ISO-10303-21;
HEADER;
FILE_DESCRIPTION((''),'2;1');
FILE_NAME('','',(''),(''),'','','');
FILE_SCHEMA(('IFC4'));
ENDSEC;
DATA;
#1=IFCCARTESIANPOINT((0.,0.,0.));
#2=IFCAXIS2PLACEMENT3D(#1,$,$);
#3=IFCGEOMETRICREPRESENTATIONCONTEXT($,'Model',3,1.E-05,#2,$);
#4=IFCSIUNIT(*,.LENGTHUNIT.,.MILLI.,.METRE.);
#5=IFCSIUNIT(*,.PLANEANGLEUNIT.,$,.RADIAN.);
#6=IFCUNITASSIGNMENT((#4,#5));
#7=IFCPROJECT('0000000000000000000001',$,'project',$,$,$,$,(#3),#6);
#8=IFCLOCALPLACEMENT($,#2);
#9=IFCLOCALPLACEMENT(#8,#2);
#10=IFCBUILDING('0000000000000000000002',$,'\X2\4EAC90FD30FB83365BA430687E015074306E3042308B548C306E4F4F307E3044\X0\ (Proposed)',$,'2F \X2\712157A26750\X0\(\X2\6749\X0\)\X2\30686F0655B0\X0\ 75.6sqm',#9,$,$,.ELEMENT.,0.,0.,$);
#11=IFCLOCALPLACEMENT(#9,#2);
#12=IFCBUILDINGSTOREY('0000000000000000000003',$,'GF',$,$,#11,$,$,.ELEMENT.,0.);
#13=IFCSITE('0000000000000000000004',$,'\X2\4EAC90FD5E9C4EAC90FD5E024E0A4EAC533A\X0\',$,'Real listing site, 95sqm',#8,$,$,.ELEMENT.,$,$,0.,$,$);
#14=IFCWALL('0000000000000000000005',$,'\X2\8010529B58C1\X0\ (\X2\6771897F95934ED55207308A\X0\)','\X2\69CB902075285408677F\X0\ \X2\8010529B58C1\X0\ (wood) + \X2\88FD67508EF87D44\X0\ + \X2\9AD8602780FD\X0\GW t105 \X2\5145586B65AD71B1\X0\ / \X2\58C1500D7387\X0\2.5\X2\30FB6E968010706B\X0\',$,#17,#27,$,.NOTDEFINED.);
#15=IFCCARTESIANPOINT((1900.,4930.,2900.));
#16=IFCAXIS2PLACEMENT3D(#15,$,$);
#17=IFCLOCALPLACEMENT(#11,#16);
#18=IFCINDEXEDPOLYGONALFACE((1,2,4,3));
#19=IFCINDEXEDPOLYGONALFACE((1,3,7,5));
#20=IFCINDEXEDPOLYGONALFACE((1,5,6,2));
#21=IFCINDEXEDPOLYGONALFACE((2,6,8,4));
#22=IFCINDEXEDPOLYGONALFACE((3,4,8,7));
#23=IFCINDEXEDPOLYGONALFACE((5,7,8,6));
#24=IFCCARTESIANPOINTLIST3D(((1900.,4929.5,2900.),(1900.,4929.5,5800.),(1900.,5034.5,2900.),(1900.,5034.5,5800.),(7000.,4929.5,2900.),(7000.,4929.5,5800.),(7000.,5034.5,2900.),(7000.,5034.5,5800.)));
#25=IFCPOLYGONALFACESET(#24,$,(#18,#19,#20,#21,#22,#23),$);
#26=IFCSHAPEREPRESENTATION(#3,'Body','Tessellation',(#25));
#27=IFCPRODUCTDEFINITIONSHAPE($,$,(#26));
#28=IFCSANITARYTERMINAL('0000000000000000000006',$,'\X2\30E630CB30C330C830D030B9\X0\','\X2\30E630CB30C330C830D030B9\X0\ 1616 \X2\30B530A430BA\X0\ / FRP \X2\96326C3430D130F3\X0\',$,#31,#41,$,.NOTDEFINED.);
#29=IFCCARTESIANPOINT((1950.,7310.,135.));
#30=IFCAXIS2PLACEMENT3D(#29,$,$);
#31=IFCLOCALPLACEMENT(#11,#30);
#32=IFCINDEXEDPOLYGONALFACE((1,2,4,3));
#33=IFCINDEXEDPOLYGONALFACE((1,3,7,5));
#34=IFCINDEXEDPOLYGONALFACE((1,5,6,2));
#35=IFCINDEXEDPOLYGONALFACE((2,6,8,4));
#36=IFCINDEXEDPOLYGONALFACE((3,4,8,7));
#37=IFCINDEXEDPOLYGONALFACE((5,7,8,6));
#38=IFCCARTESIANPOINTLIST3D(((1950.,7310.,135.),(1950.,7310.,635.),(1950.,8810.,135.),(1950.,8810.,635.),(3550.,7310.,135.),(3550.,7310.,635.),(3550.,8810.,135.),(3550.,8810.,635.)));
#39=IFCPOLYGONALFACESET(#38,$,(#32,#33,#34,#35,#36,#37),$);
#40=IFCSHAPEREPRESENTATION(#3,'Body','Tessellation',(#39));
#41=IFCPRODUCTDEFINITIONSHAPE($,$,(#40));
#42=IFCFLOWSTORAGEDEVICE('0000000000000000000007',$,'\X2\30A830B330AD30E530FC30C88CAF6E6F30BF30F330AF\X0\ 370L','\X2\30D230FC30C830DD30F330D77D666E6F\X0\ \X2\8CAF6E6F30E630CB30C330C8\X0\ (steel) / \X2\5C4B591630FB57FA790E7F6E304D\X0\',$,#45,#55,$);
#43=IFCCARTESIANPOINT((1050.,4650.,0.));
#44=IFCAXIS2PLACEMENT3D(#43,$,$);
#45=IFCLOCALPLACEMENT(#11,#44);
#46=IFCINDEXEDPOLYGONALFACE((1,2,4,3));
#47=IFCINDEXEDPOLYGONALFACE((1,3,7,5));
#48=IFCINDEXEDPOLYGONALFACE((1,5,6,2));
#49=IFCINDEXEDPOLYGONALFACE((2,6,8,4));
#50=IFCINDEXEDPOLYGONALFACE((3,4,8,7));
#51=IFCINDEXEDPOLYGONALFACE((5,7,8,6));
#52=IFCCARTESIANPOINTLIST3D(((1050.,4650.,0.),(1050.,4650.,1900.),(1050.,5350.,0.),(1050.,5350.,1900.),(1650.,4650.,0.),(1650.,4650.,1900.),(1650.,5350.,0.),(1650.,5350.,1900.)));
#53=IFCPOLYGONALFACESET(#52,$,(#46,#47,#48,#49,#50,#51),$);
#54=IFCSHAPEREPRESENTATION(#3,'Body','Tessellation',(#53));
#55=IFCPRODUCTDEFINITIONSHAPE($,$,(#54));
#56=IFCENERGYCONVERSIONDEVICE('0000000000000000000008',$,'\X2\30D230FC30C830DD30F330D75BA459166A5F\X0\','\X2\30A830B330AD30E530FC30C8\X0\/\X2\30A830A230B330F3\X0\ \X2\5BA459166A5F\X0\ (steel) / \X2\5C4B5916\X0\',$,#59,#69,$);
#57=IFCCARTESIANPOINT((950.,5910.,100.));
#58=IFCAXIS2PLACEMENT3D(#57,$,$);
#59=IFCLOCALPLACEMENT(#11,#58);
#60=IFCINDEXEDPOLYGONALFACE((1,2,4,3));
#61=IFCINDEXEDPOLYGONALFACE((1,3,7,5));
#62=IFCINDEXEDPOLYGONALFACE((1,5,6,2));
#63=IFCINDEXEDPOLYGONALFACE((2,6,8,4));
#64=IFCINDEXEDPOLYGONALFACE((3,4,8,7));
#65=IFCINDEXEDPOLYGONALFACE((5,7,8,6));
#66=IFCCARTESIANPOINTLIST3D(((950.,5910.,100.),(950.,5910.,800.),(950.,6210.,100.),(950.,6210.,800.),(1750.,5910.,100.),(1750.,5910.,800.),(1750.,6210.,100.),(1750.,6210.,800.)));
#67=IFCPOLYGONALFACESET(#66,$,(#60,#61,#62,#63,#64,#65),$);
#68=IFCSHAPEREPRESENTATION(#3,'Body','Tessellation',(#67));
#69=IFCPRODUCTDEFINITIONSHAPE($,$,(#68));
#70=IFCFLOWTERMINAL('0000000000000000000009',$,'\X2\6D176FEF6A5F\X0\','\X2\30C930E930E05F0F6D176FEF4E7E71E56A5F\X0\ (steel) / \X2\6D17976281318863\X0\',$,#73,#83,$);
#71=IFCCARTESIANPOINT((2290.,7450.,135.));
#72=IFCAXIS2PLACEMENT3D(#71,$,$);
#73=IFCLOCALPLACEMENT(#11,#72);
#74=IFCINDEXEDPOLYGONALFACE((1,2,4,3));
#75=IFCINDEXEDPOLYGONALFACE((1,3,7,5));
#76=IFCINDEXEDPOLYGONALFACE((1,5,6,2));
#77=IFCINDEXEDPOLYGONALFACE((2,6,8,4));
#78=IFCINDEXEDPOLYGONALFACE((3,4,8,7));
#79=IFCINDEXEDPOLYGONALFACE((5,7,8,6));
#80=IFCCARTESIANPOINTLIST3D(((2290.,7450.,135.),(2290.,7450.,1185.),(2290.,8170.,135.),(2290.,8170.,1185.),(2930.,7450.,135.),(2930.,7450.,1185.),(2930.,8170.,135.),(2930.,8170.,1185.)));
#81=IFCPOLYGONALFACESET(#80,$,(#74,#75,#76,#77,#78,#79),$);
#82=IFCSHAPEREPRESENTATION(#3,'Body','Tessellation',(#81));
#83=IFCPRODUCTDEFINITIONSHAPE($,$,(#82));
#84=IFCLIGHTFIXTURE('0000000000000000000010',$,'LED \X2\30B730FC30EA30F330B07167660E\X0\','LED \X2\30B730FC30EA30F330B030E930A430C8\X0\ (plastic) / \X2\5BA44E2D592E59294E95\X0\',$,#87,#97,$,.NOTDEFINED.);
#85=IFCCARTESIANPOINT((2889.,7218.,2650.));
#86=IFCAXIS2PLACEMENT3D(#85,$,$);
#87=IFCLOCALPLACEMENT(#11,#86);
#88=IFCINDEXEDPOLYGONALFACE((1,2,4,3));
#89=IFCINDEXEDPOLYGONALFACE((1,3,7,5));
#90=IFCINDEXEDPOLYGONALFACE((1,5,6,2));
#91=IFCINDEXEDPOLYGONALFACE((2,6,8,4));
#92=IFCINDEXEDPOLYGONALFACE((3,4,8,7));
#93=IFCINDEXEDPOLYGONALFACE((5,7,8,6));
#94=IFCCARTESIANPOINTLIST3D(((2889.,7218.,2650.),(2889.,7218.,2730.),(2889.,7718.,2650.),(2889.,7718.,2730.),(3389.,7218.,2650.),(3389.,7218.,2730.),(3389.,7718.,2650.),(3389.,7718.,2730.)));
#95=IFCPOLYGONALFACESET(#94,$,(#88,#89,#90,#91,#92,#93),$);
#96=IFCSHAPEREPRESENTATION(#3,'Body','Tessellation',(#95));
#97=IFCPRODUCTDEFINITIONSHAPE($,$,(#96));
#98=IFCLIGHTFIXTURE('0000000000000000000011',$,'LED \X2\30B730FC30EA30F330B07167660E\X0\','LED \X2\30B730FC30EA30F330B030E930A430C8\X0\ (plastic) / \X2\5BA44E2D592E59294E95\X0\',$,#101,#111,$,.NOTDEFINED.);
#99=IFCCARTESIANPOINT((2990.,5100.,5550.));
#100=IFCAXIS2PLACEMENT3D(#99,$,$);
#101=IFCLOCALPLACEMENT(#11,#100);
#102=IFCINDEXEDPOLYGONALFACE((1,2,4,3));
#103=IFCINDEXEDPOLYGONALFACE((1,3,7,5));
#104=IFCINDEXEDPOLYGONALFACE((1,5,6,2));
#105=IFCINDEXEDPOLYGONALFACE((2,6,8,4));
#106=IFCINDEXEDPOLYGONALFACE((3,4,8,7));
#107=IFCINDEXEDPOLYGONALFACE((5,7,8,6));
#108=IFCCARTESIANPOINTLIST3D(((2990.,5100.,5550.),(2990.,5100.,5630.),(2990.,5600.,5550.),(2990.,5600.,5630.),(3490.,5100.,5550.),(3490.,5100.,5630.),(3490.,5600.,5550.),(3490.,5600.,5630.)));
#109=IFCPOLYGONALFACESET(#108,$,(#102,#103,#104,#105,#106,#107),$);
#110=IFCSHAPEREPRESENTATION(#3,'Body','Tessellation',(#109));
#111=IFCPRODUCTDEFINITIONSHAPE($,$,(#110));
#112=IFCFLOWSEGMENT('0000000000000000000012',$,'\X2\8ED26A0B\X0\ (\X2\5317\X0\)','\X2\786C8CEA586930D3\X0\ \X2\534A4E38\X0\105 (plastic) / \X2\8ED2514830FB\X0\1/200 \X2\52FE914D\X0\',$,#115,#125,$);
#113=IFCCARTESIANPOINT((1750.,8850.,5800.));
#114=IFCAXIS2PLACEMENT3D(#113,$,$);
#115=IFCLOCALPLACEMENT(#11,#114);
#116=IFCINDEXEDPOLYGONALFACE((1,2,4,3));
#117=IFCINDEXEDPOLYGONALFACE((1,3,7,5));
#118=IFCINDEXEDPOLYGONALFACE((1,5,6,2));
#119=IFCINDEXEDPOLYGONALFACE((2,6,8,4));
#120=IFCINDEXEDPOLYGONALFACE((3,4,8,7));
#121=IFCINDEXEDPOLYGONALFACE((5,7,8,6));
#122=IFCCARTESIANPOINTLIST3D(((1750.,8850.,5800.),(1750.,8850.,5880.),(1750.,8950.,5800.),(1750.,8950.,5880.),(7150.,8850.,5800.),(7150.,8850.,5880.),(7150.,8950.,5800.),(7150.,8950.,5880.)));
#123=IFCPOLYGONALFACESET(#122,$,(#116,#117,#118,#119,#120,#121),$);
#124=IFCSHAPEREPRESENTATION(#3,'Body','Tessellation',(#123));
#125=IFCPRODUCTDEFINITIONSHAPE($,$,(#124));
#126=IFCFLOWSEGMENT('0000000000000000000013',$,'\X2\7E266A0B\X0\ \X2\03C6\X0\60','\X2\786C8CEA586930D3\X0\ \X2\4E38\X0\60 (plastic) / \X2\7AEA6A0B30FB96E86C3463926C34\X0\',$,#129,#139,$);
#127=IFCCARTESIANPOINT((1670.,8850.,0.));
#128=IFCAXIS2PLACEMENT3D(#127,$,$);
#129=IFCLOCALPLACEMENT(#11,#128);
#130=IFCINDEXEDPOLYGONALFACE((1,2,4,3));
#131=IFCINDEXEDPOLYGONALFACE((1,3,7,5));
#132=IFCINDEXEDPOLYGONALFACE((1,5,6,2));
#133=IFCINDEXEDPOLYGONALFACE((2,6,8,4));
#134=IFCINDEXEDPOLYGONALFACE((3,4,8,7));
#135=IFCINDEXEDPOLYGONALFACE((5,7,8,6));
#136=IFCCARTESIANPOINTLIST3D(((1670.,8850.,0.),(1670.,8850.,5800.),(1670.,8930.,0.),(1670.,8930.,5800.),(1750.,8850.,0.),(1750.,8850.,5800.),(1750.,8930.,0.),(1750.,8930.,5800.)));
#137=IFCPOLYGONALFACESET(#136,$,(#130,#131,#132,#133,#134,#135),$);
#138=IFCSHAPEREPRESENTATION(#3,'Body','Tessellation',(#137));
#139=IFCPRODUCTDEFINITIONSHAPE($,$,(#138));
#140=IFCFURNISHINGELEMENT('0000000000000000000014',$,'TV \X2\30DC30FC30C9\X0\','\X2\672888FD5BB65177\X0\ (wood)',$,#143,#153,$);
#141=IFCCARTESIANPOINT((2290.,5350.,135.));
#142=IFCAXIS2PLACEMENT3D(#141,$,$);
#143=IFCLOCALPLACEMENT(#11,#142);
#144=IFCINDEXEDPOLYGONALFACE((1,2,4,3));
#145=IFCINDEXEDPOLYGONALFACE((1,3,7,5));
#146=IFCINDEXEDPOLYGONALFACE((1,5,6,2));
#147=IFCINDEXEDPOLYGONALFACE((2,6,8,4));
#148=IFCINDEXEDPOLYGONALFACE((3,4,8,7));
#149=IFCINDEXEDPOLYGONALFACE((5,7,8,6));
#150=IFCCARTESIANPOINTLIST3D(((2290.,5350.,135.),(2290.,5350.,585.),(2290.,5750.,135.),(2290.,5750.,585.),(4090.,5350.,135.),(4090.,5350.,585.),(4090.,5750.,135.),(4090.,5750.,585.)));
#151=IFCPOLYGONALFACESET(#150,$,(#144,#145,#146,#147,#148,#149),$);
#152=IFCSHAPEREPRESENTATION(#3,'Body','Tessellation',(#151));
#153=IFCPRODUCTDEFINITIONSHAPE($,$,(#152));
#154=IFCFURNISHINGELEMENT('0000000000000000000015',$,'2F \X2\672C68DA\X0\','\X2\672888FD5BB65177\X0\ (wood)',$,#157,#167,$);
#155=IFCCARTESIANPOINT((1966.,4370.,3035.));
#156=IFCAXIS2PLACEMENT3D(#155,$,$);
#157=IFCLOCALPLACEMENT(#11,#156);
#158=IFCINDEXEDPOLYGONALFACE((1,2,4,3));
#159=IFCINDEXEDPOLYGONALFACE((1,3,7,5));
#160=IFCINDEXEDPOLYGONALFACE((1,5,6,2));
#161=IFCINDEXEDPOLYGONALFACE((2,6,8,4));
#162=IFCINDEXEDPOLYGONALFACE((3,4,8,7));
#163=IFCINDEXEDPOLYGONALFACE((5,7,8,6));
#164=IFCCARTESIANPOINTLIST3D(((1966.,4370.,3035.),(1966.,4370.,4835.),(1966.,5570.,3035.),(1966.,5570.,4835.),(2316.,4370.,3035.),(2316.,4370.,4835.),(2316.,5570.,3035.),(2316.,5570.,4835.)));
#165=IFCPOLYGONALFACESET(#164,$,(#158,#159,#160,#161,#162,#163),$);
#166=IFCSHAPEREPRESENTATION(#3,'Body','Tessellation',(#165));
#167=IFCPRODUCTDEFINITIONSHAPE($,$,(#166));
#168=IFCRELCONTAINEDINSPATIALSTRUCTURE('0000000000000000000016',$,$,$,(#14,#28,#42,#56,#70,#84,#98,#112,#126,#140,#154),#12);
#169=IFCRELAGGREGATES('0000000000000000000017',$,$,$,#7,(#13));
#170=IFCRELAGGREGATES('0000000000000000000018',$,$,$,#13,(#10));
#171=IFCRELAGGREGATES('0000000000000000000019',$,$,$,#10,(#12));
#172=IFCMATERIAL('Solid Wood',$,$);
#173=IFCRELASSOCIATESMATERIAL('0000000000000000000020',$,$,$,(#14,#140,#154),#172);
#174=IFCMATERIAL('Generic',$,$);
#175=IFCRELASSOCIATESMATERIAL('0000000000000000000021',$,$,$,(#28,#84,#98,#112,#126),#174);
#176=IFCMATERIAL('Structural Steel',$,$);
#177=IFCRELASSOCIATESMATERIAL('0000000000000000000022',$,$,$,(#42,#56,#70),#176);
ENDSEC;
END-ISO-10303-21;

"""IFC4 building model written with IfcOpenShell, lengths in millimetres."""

from ifc_helpers import new_model, si_unit, frame, frame_2d, origin, place, context, project, spatial, rectangle, extrude, material, element, save


model = new_model("IFC4")

# Units and contexts
model_context = context("Model", 3, precision=1e-05, world=origin())
ifc_project = project(units=[si_unit("LENGTHUNIT", "METRE", prefix="MILLI"), si_unit("PLANEANGLEUNIT", "RADIAN")], contexts=[model_context])

# Site, building, storey
site_placement = place(None, origin())
site = spatial("IfcSite", under=ifc_project, at=site_placement, Name="京都府京都市上京区", ObjectType="Real listing site, 95sqm", CompositionType="ELEMENT", RefElevation=0.0)
building_placement = place(site_placement, origin())
building = spatial("IfcBuilding", under=site, at=building_placement, Name="京都・茶室と縁側のある和の住まい (Proposed)", ObjectType="2F 無垢材(杉)と漆喰 75.6sqm", CompositionType="ELEMENT", ElevationOfRefHeight=0.0, ElevationOfTerrain=0.0)
storey_placement = place(building_placement, origin())
storey = spatial("IfcBuildingStorey", under=building, at=storey_placement, Name="GF", CompositionType="ELEMENT", Elevation=0.0)

# Shared definitions
ifc_material_1 = material(Name="Solid Wood")

# Wall
wall_1_placement = place(storey_placement, frame((1900.0, 4930.0, 2900.0)))
element("IfcWall", 1, at=wall_1_placement, inside=storey, material=ifc_material_1, Name="耐力壁 (東西間仕切り)", Description="構造用合板 耐力壁 (wood) + 製材軸組 + 高性能GW t105 充填断熱 / 壁倍率2.5・準耐火", PredefinedType="NOTDEFINED", context=model_context, shape_type="SweptSolid", body=[
    extrude(rectangle(XDim=5100.0, YDim=105.0, at=frame_2d((2550.0, 52.0))), frame((1900.0, 4930.0, 2900.0)), (0.0, 0.0, 1.0), 2900.0),
])

# Sanitary terminal
ifc_material_2 = material(Name="Generic")
sanitary_terminal_placement = place(storey_placement, frame((1950.0, 7310.0, 135.0)))
element("IfcSanitaryTerminal", 2, at=sanitary_terminal_placement, inside=storey, material=ifc_material_2, Name="ユニットバス", Description="ユニットバス 1616 サイズ / FRP 防水パン", PredefinedType="NOTDEFINED", context=model_context, shape_type="SweptSolid", body=[
    extrude(rectangle(XDim=1600.0, YDim=1500.0, at=frame_2d((800.0, 750.0))), frame((1950.0, 7310.0, 135.0)), (0.0, 0.0, 1.0), 500.0),
])

# Flow storage device
ifc_material_3 = material(Name="Structural Steel")
flow_storage_device_placement = place(storey_placement, frame((1050.0, 4650.0, 0.0)))
element("IfcFlowStorageDevice", 3, at=flow_storage_device_placement, inside=storey, material=ifc_material_3, Name="エコキュート貯湯タンク 370L", Description="ヒートポンプ給湯 貯湯ユニット (steel) / 屋外・基礎置き", context=model_context, shape_type="SweptSolid", body=[
    extrude(rectangle(XDim=600.0, YDim=700.0, at=frame_2d((300.0, 350.0))), frame((1050.0, 4650.0, 0.0)), (0.0, 0.0, 1.0), 1900.0),
])

# Energy conversion device
energy_conversion_device_placement = place(storey_placement, frame((950.0, 5910.0, 100.0)))
element("IfcEnergyConversionDevice", 4, at=energy_conversion_device_placement, inside=storey, material=ifc_material_3, Name="ヒートポンプ室外機", Description="エコキュート/エアコン 室外機 (steel) / 屋外", context=model_context, shape_type="SweptSolid", body=[
    extrude(rectangle(XDim=800.0, YDim=300.0, at=frame_2d((400.0, 150.0))), frame((950.0, 5910.0, 100.0)), (0.0, 0.0, 1.0), 700.0),
])

# Flow terminal
flow_terminal_placement = place(storey_placement, frame((2290.0, 7450.0, 135.0)))
element("IfcFlowTerminal", 5, at=flow_terminal_placement, inside=storey, material=ifc_material_3, Name="洗濯機", Description="ドラム式洗濯乾燥機 (steel) / 洗面脱衣", context=model_context, shape_type="SweptSolid", body=[
    extrude(rectangle(XDim=640.0, YDim=720.0, at=frame_2d((320.0, 360.0))), frame((2290.0, 7450.0, 135.0)), (0.0, 0.0, 1.0), 1050.0),
])

# Light fixtures
light_fixture_1_placement = place(storey_placement, frame((2889.0, 7218.0, 2650.0)))
element("IfcLightFixture", 6, at=light_fixture_1_placement, inside=storey, material=ifc_material_2, Name="LED シーリング照明", Description="LED シーリングライト (plastic) / 室中央天井", PredefinedType="NOTDEFINED", context=model_context, shape_type="SweptSolid", body=[
    extrude(rectangle(XDim=500.0, YDim=500.0, at=frame_2d((250.0, 250.0))), frame((2889.0, 7218.0, 2650.0)), (0.0, 0.0, 1.0), 80.0),
])
light_fixture_2_placement = place(storey_placement, frame((2990.0, 5100.0, 5550.0)))
element("IfcLightFixture", 7, at=light_fixture_2_placement, inside=storey, material=ifc_material_2, Name="LED シーリング照明", Description="LED シーリングライト (plastic) / 室中央天井", PredefinedType="NOTDEFINED", context=model_context, shape_type="SweptSolid", body=[
    extrude(rectangle(XDim=500.0, YDim=500.0, at=frame_2d((250.0, 250.0))), frame((2990.0, 5100.0, 5550.0)), (0.0, 0.0, 1.0), 80.0),
])

# Flow segments
flow_segment_1_placement = place(storey_placement, frame((1750.0, 8850.0, 5800.0)))
element("IfcFlowSegment", 8, at=flow_segment_1_placement, inside=storey, material=ifc_material_2, Name="軒樋 (北)", Description="硬質塩ビ 半丸105 (plastic) / 軒先・1/200 勾配", context=model_context, shape_type="SweptSolid", body=[
    extrude(rectangle(XDim=5400.0, YDim=100.0, at=frame_2d((2700.0, 50.0))), frame((1750.0, 8850.0, 5800.0)), (0.0, 0.0, 1.0), 80.0),
])
flow_segment_2_placement = place(storey_placement, frame((1670.0, 8850.0, 0.0)))
element("IfcFlowSegment", 9, at=flow_segment_2_placement, inside=storey, material=ifc_material_2, Name="縦樋 φ60", Description="硬質塩ビ 丸60 (plastic) / 竪樋・雨水排水", context=model_context, shape_type="SweptSolid", body=[
    extrude(rectangle(XDim=80.0, YDim=80.0, at=frame_2d((40.0, 40.0))), frame((1670.0, 8850.0, 0.0)), (0.0, 0.0, 1.0), 5800.0),
])

# Furnishing elements
furnishing_1_placement = place(storey_placement, frame((2290.0, 5350.0, 135.0)))
element("IfcFurnishingElement", 10, at=furnishing_1_placement, inside=storey, material=ifc_material_1, Name="TV ボード", Description="木製家具 (wood)", context=model_context, shape_type="SweptSolid", body=[
    extrude(rectangle(XDim=1800.0, YDim=400.0, at=frame_2d((900.0, 200.0))), frame((2290.0, 5350.0, 135.0)), (0.0, 0.0, 1.0), 450.0),
])
furnishing_2_placement = place(storey_placement, frame((1966.0, 4370.0, 3035.0)))
element("IfcFurnishingElement", 11, at=furnishing_2_placement, inside=storey, material=ifc_material_1, Name="2F 本棚", Description="木製家具 (wood)", context=model_context, shape_type="SweptSolid", body=[
    extrude(rectangle(XDim=350.0, YDim=1200.0, at=frame_2d((175.0, 600.0))), frame((1966.0, 4370.0, 3035.0)), (0.0, 0.0, 1.0), 1800.0),
])

save(model, "model.ifc")
